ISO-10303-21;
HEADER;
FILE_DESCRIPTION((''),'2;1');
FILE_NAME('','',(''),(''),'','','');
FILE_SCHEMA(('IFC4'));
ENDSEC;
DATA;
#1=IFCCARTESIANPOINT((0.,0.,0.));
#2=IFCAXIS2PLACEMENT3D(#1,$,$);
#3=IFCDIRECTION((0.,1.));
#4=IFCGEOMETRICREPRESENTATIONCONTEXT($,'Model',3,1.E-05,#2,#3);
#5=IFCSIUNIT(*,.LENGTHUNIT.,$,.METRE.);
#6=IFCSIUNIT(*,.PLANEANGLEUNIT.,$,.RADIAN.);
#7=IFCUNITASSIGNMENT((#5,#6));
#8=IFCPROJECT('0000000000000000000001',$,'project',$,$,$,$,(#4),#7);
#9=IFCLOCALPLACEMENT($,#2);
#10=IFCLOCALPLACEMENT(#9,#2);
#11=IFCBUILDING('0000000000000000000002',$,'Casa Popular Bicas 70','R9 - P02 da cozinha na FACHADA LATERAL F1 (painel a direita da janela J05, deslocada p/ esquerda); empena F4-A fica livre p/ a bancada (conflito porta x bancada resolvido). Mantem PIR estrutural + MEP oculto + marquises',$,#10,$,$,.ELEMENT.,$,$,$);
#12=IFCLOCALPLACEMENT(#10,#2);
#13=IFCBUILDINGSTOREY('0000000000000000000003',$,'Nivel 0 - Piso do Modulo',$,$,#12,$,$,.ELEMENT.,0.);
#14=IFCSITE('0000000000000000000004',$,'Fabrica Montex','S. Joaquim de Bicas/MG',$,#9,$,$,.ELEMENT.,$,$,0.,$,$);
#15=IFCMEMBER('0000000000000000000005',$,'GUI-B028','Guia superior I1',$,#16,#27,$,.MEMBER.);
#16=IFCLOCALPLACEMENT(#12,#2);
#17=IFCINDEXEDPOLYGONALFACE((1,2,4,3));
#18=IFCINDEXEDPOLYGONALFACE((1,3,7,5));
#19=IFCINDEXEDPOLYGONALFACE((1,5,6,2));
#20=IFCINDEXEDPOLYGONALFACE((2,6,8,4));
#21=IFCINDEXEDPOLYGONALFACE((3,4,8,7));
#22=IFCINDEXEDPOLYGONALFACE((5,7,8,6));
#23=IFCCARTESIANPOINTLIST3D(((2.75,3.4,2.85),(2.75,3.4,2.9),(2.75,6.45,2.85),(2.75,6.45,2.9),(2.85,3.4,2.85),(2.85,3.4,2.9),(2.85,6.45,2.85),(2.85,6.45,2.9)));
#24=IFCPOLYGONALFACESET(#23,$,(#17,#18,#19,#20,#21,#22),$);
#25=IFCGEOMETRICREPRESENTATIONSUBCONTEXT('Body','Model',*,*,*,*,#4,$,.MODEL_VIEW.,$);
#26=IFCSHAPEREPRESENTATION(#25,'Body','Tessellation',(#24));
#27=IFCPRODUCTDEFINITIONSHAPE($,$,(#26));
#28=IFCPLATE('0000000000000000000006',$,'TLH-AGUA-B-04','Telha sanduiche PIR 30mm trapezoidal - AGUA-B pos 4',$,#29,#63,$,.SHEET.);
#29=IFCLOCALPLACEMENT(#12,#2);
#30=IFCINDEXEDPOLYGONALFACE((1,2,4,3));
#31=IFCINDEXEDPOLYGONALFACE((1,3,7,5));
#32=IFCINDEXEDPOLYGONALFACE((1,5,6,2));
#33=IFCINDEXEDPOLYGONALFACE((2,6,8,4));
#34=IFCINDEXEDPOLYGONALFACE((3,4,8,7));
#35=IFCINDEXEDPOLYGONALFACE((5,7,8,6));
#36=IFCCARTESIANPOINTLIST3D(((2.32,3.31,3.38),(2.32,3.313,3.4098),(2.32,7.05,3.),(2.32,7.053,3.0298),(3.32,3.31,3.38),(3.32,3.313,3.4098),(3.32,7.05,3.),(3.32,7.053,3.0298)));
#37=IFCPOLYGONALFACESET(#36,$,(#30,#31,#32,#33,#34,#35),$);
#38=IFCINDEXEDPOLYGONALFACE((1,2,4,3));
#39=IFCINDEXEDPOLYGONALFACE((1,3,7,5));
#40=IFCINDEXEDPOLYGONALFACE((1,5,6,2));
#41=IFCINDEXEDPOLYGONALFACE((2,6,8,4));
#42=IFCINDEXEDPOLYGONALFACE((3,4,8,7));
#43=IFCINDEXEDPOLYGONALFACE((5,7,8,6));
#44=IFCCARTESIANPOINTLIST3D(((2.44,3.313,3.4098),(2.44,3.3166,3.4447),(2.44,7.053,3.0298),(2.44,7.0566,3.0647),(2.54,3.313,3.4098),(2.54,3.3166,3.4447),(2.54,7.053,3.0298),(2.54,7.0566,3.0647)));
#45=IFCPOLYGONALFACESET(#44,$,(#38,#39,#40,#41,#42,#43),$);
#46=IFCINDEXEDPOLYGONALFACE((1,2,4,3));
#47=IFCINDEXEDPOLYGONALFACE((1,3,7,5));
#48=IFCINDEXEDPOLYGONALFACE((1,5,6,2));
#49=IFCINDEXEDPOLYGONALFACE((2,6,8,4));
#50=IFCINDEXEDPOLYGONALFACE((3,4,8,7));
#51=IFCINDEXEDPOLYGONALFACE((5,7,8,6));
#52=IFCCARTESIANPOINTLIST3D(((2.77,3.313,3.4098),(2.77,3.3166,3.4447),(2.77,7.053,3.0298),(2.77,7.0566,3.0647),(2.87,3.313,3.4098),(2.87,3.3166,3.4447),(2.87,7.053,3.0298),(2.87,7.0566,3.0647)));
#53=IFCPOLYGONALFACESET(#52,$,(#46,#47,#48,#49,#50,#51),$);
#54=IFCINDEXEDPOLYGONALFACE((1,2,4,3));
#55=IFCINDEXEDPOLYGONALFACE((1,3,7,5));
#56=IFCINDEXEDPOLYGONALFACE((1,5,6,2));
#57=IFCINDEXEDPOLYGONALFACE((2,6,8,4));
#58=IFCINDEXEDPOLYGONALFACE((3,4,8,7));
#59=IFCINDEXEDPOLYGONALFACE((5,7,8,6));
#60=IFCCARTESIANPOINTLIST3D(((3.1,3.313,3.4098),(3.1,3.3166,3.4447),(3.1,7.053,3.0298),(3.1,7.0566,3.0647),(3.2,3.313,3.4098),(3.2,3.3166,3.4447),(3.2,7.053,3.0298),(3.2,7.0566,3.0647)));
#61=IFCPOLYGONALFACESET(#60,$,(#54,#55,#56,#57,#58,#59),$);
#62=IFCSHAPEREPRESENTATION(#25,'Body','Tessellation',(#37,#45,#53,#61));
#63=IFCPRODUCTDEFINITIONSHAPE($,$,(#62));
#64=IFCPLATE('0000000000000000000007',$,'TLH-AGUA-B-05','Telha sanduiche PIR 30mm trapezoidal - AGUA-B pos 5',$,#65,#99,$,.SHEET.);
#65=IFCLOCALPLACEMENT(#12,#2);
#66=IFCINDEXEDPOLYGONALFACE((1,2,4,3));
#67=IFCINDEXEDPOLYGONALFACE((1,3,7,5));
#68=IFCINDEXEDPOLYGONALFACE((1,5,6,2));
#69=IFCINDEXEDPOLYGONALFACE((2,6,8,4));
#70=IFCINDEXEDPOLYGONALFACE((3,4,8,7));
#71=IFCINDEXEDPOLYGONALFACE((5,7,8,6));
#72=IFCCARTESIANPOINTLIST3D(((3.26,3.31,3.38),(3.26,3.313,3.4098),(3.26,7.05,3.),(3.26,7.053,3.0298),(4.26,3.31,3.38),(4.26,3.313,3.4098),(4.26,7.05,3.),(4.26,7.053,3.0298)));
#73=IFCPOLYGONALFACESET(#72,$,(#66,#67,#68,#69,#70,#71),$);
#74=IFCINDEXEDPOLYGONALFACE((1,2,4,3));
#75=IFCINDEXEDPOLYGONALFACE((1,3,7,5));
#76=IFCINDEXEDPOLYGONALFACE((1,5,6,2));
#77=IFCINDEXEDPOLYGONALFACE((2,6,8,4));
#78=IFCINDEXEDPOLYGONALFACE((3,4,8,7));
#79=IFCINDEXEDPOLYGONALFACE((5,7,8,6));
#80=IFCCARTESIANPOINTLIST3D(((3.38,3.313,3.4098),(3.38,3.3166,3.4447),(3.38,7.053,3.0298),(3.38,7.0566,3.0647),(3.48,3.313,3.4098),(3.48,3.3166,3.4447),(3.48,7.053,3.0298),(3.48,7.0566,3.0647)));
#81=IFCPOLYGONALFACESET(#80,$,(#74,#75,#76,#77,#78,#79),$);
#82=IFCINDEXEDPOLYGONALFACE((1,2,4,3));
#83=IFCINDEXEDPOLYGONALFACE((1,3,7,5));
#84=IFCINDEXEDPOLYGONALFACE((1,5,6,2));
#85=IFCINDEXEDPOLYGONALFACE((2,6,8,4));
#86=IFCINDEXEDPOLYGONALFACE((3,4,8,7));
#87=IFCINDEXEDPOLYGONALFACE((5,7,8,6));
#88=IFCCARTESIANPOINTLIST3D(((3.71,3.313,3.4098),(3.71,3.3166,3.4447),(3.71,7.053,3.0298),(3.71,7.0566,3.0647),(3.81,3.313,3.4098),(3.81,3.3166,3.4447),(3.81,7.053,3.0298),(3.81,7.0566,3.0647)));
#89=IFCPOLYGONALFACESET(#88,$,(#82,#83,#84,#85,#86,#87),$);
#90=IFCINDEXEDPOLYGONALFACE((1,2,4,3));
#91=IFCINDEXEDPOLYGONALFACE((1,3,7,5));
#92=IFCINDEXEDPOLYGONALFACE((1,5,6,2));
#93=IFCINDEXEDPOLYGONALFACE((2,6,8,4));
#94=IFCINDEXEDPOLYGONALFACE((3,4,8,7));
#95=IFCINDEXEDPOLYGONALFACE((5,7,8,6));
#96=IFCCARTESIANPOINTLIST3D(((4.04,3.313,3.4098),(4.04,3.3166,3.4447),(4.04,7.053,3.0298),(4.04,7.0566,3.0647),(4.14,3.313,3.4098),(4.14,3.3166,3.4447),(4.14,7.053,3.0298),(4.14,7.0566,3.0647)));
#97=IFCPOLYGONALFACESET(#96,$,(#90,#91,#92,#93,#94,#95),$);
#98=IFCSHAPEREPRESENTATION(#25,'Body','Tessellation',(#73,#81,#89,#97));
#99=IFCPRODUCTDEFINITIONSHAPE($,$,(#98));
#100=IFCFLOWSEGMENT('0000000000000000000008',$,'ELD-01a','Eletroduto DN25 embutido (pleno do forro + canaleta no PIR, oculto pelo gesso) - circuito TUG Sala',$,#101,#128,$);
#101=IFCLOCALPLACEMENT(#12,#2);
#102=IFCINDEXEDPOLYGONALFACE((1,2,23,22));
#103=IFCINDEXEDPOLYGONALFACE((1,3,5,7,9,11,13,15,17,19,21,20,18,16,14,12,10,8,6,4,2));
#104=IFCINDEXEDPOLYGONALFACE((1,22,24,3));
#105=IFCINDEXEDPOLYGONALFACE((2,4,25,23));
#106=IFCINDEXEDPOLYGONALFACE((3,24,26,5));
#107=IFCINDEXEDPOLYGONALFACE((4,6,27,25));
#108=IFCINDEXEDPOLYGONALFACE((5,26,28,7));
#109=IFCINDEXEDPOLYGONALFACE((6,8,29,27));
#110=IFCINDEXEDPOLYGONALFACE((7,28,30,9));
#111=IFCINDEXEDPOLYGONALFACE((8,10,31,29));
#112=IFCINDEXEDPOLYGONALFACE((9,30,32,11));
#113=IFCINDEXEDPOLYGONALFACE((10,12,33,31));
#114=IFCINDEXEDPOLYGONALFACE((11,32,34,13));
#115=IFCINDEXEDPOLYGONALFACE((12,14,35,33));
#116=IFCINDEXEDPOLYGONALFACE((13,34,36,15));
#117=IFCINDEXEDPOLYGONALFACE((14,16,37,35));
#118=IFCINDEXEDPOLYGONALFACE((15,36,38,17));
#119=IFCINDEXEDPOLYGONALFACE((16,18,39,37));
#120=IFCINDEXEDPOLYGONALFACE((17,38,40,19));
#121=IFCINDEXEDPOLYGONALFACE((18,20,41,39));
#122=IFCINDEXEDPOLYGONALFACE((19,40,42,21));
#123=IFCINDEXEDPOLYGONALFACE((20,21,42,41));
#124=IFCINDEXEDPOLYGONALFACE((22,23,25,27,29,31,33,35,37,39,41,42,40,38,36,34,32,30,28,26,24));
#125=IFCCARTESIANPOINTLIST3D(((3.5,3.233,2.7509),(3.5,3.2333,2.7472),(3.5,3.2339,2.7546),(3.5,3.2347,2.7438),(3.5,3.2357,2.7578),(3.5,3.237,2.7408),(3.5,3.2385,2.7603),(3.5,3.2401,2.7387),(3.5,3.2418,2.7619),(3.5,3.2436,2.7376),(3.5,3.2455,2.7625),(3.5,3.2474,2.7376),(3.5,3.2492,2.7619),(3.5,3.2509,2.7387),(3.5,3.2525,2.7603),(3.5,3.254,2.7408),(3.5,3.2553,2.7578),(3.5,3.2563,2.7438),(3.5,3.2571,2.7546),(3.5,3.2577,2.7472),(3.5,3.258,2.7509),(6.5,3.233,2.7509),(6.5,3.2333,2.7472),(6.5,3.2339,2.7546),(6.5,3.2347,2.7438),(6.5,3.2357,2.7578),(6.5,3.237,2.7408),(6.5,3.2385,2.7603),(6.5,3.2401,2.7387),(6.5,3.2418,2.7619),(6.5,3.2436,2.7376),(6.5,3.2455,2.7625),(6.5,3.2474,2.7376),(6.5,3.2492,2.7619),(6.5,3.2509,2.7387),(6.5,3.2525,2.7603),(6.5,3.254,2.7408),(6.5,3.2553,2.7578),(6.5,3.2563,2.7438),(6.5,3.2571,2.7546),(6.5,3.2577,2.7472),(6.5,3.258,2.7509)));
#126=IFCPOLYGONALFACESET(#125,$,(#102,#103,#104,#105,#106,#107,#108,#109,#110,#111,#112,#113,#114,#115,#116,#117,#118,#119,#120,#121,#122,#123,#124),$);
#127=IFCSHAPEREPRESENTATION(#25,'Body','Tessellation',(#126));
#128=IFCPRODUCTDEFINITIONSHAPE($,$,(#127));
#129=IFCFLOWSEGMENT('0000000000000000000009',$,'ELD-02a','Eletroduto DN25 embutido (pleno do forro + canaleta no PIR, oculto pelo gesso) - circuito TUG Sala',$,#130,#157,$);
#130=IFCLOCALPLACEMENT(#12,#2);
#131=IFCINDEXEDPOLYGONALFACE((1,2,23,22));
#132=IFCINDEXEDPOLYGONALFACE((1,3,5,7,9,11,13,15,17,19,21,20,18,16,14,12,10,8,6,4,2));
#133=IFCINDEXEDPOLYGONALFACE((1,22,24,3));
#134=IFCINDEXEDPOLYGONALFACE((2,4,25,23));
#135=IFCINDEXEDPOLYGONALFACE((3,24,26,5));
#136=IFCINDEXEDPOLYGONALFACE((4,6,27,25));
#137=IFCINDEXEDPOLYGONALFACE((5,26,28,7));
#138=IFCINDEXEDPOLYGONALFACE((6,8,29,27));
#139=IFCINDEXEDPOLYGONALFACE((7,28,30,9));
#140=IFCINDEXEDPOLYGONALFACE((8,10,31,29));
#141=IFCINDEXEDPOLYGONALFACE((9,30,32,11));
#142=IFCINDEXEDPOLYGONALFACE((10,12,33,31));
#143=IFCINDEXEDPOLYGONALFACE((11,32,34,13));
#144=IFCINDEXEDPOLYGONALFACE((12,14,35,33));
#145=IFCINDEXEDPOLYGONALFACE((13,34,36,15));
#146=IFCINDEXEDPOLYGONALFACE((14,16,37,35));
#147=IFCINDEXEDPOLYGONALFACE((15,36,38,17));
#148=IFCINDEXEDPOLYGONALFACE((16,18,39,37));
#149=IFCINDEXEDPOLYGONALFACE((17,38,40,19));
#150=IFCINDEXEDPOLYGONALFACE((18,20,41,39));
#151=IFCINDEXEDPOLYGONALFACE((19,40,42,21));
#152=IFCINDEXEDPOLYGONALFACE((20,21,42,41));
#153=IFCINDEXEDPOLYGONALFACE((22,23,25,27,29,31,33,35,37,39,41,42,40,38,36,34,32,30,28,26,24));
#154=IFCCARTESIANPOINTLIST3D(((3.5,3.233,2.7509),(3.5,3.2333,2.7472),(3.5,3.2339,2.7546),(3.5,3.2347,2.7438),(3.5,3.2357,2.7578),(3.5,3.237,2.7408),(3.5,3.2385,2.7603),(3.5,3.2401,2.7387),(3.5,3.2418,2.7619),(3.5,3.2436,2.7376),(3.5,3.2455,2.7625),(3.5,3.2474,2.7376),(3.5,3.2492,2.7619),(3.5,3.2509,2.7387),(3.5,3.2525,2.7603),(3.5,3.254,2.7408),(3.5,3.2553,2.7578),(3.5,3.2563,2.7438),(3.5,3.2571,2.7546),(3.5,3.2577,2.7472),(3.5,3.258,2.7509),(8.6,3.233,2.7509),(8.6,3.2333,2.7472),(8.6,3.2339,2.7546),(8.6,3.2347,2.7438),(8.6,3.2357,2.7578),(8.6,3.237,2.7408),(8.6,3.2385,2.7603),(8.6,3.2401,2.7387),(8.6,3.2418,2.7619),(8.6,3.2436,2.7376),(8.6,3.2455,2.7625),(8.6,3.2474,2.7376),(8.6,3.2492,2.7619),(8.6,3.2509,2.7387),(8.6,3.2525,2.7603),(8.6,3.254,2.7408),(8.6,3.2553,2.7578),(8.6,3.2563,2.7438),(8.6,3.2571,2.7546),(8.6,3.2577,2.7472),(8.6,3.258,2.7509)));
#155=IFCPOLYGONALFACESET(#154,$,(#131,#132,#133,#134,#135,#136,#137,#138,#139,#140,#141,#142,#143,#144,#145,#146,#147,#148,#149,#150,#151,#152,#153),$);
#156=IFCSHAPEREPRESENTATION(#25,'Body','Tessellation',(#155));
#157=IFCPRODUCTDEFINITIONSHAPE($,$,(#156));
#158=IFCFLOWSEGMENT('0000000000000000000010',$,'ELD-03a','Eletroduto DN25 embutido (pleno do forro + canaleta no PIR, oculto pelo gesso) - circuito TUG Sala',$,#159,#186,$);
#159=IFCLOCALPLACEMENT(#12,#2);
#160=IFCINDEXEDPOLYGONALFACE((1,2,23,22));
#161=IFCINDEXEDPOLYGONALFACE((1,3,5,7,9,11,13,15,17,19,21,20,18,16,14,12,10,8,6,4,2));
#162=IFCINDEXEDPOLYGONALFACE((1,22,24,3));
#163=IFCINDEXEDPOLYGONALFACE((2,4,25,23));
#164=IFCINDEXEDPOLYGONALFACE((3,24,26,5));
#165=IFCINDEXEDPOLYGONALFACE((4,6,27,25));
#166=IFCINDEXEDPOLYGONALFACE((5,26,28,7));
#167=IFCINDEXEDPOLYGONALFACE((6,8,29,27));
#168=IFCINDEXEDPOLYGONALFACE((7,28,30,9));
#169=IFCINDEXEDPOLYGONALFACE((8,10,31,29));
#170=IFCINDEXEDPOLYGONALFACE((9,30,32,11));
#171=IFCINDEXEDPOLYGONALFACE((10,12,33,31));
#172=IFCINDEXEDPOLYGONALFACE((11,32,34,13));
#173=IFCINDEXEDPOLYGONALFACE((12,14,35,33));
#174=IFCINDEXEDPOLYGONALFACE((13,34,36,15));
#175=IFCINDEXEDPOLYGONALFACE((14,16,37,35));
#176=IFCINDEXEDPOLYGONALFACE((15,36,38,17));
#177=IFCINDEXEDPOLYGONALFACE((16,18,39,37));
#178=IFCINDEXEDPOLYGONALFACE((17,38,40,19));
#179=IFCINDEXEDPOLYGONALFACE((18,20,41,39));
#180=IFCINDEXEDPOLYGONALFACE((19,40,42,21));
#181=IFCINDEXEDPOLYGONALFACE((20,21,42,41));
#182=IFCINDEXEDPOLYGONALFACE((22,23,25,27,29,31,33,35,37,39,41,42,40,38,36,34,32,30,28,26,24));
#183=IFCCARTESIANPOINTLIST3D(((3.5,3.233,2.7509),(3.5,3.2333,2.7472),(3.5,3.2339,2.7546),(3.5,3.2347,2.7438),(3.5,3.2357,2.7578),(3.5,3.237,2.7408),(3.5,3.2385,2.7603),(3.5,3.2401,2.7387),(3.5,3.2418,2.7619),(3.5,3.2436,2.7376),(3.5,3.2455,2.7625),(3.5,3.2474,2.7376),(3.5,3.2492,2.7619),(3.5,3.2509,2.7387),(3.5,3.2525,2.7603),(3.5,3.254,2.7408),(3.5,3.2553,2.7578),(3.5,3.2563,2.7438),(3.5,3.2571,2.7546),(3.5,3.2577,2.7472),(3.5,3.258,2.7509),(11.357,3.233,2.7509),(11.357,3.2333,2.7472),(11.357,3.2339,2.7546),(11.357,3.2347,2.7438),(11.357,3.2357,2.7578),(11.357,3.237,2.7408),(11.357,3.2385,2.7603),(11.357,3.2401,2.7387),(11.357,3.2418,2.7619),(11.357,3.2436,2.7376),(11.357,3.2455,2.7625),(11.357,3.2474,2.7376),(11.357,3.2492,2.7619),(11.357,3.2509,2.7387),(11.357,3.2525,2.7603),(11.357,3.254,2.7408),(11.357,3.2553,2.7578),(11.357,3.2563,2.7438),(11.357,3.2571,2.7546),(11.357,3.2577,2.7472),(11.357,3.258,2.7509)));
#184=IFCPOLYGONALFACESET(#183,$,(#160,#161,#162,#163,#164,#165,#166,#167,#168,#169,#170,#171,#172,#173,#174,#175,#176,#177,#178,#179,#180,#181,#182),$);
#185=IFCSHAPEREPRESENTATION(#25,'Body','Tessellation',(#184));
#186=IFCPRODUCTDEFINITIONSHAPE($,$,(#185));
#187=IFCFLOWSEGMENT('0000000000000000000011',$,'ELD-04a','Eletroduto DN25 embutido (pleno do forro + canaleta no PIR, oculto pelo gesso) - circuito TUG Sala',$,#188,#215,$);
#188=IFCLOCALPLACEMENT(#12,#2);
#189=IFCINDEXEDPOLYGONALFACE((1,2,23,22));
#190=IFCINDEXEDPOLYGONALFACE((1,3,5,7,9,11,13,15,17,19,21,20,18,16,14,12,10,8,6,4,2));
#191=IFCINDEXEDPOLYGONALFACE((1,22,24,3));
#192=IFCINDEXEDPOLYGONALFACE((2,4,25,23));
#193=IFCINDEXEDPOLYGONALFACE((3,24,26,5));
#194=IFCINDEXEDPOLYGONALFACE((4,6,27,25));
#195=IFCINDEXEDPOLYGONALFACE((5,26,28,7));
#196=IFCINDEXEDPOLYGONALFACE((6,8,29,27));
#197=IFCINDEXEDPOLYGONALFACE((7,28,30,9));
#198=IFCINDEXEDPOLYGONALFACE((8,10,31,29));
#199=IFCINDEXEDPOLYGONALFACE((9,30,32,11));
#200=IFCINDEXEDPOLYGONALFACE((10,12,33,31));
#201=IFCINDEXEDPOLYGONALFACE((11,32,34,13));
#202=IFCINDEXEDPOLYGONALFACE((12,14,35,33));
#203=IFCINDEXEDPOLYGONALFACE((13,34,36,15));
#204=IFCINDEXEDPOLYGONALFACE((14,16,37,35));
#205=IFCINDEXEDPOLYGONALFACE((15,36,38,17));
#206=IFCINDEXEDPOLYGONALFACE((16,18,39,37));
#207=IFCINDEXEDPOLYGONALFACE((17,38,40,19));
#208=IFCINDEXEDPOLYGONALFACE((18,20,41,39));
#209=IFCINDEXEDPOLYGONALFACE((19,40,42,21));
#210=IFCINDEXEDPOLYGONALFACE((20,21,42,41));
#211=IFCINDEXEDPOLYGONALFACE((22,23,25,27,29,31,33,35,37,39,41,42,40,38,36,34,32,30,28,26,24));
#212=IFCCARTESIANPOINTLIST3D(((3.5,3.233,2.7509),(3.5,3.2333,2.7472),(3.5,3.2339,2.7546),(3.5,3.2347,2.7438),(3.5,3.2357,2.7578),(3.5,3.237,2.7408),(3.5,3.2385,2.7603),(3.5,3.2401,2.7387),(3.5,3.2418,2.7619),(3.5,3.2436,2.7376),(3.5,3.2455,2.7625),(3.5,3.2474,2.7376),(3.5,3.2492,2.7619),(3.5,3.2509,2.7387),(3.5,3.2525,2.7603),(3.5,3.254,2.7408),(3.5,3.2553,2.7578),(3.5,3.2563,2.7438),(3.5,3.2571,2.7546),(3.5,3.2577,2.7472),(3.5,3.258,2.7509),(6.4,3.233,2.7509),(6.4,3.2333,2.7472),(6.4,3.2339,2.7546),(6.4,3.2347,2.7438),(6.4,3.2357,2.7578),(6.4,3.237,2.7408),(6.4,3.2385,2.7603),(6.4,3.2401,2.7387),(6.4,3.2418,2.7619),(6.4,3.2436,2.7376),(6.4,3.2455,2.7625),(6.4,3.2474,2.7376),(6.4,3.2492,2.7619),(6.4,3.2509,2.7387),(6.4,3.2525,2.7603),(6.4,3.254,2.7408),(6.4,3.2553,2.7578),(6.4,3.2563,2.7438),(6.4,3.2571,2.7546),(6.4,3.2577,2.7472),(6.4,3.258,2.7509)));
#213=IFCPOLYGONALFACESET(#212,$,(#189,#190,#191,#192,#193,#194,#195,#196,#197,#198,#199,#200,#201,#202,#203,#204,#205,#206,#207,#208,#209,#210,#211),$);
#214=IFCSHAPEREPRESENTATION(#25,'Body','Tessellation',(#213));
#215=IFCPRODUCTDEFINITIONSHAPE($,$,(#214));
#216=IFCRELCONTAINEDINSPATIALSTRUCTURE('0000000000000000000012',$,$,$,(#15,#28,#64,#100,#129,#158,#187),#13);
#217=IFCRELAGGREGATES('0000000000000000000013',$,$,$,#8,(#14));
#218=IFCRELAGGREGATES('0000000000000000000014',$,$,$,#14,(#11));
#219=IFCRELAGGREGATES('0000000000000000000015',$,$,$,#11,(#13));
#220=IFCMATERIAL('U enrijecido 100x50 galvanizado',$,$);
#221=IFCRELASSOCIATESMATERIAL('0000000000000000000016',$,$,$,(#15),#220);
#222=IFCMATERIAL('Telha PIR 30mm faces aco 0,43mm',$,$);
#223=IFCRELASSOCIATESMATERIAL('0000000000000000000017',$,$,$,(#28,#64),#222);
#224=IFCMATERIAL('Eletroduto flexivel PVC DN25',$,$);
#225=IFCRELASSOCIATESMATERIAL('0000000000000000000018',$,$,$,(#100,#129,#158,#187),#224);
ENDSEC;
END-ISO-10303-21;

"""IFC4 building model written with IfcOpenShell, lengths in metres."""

from ifc_helpers import new_model, si_unit, direction, frame, frame_2d, origin, origin_2d, place, context, subcontext, project, spatial, rectangle, circle, extrude, material, element, save


model = new_model("IFC4")

# Units and contexts
model_context = context("Model", 3, precision=1e-05, world=origin(), true_north=direction((0.0, 1.0)))
body_context = subcontext(model_context, "Body", "Model", "MODEL_VIEW")
ifc_project = project(units=[si_unit("LENGTHUNIT", "METRE"), si_unit("PLANEANGLEUNIT", "RADIAN")], contexts=[model_context])

# Site, building, storey
site_placement = place(None, origin())
site = spatial("IfcSite", under=ifc_project, at=site_placement, Name="Fabrica Montex", Description="S. Joaquim de Bicas/MG", CompositionType="ELEMENT", RefElevation=0.0)
building_placement = place(site_placement, origin())
building = spatial("IfcBuilding", under=site, at=building_placement, Name="Casa Popular Bicas 70", Description="R9 - P02 da cozinha na FACHADA LATERAL F1 (painel a direita da janela J05, deslocada p/ esquerda); empena F4-A fica livre p/ a bancada (conflito porta x bancada resolvido). Mantem PIR estrutural + MEP oculto + marquises", CompositionType="ELEMENT")
storey_placement = place(building_placement, origin())
storey = spatial("IfcBuildingStorey", under=building, at=storey_placement, Name="Nivel 0 - Piso do Modulo", CompositionType="ELEMENT", Elevation=0.0)

# Member
ifc_material_1 = material(Name="U enrijecido 100x50 galvanizado")
member_placement = place(storey_placement, frame((2.8, 3.4, 2.875), z_axis=(0.0, 1.0, 0.0), x_axis=(0.0, 0.0, 1.0)))
element("IfcMember", 1, at=member_placement, inside=storey, material=ifc_material_1, Name="GUI-B028", Description="Guia superior I1", PredefinedType="MEMBER", context=body_context, shape_type="SweptSolid", body=[
    extrude(rectangle(XDim=0.05, YDim=0.1, at=origin_2d()), origin(), (0.0, 0.0, 1.0), 3.05),
])

# Plates
ifc_material_2 = material(Name="Telha PIR 30mm faces aco 0,43mm")
for number, where, z_axis, x_axis, name, description in (
    (2, (2.32, 3.31, 3.38), (0.0, 0.101084, 0.994878), (1.0, 0.0, 0.0), "TLH-AGUA-B-04", "Telha sanduiche PIR 30mm trapezoidal - AGUA-B pos 4"),
    (3, (3.26, 3.31, 3.38), (0.0, 0.101084, 0.994878), (1.0, 0.0, 0.0), "TLH-AGUA-B-05", "Telha sanduiche PIR 30mm trapezoidal - AGUA-B pos 5"),
):
    element("IfcPlate", number, at=place(storey_placement, frame(where, z_axis=z_axis, x_axis=x_axis)), inside=storey, material=ifc_material_2, Name=name, Description=description, PredefinedType="SHEET", context=body_context, shape_type="SweptSolid", body=[
        extrude(rectangle(XDim=1.0, YDim=3.7593, at=frame_2d((0.5, 1.8796))), origin(), (0.0, 0.0, 1.0), 0.03),
        extrude(rectangle(XDim=0.1, YDim=3.7593, at=frame_2d((0.17, 1.8796))), frame((0.0, 0.0, 0.03)), (0.0, 0.0, 1.0), 0.035),
        extrude(rectangle(XDim=0.1, YDim=3.7593, at=frame_2d((0.5, 1.8796))), frame((0.0, 0.0, 0.03)), (0.0, 0.0, 1.0), 0.035),
        extrude(rectangle(XDim=0.1, YDim=3.7593, at=frame_2d((0.83, 1.8796))), frame((0.0, 0.0, 0.03)), (0.0, 0.0, 1.0), 0.035),
    ])

# Flow segments
ifc_material_3 = material(Name="Eletroduto flexivel PVC DN25")
flow_segment_1_placement = place(storey_placement, frame((3.5, 3.2455, 2.75), z_axis=(1.0, 0.0, 0.0), x_axis=(0.0, 0.0, 1.0)))
element("IfcFlowSegment", 4, at=flow_segment_1_placement, inside=storey, material=ifc_material_3, Name="ELD-01a", Description="Eletroduto DN25 embutido (pleno do forro + canaleta no PIR, oculto pelo gesso) - circuito TUG Sala", context=body_context, shape_type="SweptSolid", body=[
    extrude(circle(Radius=0.0125, at=origin_2d()), origin(), (0.0, 0.0, 1.0), 3.0),
])
flow_segment_2_placement = place(storey_placement, frame((3.5, 3.2455, 2.75), z_axis=(1.0, 0.0, 0.0), x_axis=(0.0, 0.0, 1.0)))
element("IfcFlowSegment", 5, at=flow_segment_2_placement, inside=storey, material=ifc_material_3, Name="ELD-02a", Description="Eletroduto DN25 embutido (pleno do forro + canaleta no PIR, oculto pelo gesso) - circuito TUG Sala", context=body_context, shape_type="SweptSolid", body=[
    extrude(circle(Radius=0.0125, at=origin_2d()), origin(), (0.0, 0.0, 1.0), 5.1),
])
flow_segment_3_placement = place(storey_placement, frame((3.5, 3.2455, 2.75), z_axis=(1.0, 0.0, 0.0), x_axis=(0.0, 0.0, 1.0)))
element("IfcFlowSegment", 6, at=flow_segment_3_placement, inside=storey, material=ifc_material_3, Name="ELD-03a", Description="Eletroduto DN25 embutido (pleno do forro + canaleta no PIR, oculto pelo gesso) - circuito TUG Sala", context=body_context, shape_type="SweptSolid", body=[
    extrude(circle(Radius=0.0125, at=origin_2d()), origin(), (0.0, 0.0, 1.0), 7.857),
])
flow_segment_4_placement = place(storey_placement, frame((3.5, 3.2455, 2.75), z_axis=(1.0, 0.0, 0.0), x_axis=(0.0, 0.0, 1.0)))
element("IfcFlowSegment", 7, at=flow_segment_4_placement, inside=storey, material=ifc_material_3, Name="ELD-04a", Description="Eletroduto DN25 embutido (pleno do forro + canaleta no PIR, oculto pelo gesso) - circuito TUG Sala", context=body_context, shape_type="SweptSolid", body=[
    extrude(circle(Radius=0.0125, at=origin_2d()), origin(), (0.0, 0.0, 1.0), 2.9),
])

save(model, "model.ifc")
